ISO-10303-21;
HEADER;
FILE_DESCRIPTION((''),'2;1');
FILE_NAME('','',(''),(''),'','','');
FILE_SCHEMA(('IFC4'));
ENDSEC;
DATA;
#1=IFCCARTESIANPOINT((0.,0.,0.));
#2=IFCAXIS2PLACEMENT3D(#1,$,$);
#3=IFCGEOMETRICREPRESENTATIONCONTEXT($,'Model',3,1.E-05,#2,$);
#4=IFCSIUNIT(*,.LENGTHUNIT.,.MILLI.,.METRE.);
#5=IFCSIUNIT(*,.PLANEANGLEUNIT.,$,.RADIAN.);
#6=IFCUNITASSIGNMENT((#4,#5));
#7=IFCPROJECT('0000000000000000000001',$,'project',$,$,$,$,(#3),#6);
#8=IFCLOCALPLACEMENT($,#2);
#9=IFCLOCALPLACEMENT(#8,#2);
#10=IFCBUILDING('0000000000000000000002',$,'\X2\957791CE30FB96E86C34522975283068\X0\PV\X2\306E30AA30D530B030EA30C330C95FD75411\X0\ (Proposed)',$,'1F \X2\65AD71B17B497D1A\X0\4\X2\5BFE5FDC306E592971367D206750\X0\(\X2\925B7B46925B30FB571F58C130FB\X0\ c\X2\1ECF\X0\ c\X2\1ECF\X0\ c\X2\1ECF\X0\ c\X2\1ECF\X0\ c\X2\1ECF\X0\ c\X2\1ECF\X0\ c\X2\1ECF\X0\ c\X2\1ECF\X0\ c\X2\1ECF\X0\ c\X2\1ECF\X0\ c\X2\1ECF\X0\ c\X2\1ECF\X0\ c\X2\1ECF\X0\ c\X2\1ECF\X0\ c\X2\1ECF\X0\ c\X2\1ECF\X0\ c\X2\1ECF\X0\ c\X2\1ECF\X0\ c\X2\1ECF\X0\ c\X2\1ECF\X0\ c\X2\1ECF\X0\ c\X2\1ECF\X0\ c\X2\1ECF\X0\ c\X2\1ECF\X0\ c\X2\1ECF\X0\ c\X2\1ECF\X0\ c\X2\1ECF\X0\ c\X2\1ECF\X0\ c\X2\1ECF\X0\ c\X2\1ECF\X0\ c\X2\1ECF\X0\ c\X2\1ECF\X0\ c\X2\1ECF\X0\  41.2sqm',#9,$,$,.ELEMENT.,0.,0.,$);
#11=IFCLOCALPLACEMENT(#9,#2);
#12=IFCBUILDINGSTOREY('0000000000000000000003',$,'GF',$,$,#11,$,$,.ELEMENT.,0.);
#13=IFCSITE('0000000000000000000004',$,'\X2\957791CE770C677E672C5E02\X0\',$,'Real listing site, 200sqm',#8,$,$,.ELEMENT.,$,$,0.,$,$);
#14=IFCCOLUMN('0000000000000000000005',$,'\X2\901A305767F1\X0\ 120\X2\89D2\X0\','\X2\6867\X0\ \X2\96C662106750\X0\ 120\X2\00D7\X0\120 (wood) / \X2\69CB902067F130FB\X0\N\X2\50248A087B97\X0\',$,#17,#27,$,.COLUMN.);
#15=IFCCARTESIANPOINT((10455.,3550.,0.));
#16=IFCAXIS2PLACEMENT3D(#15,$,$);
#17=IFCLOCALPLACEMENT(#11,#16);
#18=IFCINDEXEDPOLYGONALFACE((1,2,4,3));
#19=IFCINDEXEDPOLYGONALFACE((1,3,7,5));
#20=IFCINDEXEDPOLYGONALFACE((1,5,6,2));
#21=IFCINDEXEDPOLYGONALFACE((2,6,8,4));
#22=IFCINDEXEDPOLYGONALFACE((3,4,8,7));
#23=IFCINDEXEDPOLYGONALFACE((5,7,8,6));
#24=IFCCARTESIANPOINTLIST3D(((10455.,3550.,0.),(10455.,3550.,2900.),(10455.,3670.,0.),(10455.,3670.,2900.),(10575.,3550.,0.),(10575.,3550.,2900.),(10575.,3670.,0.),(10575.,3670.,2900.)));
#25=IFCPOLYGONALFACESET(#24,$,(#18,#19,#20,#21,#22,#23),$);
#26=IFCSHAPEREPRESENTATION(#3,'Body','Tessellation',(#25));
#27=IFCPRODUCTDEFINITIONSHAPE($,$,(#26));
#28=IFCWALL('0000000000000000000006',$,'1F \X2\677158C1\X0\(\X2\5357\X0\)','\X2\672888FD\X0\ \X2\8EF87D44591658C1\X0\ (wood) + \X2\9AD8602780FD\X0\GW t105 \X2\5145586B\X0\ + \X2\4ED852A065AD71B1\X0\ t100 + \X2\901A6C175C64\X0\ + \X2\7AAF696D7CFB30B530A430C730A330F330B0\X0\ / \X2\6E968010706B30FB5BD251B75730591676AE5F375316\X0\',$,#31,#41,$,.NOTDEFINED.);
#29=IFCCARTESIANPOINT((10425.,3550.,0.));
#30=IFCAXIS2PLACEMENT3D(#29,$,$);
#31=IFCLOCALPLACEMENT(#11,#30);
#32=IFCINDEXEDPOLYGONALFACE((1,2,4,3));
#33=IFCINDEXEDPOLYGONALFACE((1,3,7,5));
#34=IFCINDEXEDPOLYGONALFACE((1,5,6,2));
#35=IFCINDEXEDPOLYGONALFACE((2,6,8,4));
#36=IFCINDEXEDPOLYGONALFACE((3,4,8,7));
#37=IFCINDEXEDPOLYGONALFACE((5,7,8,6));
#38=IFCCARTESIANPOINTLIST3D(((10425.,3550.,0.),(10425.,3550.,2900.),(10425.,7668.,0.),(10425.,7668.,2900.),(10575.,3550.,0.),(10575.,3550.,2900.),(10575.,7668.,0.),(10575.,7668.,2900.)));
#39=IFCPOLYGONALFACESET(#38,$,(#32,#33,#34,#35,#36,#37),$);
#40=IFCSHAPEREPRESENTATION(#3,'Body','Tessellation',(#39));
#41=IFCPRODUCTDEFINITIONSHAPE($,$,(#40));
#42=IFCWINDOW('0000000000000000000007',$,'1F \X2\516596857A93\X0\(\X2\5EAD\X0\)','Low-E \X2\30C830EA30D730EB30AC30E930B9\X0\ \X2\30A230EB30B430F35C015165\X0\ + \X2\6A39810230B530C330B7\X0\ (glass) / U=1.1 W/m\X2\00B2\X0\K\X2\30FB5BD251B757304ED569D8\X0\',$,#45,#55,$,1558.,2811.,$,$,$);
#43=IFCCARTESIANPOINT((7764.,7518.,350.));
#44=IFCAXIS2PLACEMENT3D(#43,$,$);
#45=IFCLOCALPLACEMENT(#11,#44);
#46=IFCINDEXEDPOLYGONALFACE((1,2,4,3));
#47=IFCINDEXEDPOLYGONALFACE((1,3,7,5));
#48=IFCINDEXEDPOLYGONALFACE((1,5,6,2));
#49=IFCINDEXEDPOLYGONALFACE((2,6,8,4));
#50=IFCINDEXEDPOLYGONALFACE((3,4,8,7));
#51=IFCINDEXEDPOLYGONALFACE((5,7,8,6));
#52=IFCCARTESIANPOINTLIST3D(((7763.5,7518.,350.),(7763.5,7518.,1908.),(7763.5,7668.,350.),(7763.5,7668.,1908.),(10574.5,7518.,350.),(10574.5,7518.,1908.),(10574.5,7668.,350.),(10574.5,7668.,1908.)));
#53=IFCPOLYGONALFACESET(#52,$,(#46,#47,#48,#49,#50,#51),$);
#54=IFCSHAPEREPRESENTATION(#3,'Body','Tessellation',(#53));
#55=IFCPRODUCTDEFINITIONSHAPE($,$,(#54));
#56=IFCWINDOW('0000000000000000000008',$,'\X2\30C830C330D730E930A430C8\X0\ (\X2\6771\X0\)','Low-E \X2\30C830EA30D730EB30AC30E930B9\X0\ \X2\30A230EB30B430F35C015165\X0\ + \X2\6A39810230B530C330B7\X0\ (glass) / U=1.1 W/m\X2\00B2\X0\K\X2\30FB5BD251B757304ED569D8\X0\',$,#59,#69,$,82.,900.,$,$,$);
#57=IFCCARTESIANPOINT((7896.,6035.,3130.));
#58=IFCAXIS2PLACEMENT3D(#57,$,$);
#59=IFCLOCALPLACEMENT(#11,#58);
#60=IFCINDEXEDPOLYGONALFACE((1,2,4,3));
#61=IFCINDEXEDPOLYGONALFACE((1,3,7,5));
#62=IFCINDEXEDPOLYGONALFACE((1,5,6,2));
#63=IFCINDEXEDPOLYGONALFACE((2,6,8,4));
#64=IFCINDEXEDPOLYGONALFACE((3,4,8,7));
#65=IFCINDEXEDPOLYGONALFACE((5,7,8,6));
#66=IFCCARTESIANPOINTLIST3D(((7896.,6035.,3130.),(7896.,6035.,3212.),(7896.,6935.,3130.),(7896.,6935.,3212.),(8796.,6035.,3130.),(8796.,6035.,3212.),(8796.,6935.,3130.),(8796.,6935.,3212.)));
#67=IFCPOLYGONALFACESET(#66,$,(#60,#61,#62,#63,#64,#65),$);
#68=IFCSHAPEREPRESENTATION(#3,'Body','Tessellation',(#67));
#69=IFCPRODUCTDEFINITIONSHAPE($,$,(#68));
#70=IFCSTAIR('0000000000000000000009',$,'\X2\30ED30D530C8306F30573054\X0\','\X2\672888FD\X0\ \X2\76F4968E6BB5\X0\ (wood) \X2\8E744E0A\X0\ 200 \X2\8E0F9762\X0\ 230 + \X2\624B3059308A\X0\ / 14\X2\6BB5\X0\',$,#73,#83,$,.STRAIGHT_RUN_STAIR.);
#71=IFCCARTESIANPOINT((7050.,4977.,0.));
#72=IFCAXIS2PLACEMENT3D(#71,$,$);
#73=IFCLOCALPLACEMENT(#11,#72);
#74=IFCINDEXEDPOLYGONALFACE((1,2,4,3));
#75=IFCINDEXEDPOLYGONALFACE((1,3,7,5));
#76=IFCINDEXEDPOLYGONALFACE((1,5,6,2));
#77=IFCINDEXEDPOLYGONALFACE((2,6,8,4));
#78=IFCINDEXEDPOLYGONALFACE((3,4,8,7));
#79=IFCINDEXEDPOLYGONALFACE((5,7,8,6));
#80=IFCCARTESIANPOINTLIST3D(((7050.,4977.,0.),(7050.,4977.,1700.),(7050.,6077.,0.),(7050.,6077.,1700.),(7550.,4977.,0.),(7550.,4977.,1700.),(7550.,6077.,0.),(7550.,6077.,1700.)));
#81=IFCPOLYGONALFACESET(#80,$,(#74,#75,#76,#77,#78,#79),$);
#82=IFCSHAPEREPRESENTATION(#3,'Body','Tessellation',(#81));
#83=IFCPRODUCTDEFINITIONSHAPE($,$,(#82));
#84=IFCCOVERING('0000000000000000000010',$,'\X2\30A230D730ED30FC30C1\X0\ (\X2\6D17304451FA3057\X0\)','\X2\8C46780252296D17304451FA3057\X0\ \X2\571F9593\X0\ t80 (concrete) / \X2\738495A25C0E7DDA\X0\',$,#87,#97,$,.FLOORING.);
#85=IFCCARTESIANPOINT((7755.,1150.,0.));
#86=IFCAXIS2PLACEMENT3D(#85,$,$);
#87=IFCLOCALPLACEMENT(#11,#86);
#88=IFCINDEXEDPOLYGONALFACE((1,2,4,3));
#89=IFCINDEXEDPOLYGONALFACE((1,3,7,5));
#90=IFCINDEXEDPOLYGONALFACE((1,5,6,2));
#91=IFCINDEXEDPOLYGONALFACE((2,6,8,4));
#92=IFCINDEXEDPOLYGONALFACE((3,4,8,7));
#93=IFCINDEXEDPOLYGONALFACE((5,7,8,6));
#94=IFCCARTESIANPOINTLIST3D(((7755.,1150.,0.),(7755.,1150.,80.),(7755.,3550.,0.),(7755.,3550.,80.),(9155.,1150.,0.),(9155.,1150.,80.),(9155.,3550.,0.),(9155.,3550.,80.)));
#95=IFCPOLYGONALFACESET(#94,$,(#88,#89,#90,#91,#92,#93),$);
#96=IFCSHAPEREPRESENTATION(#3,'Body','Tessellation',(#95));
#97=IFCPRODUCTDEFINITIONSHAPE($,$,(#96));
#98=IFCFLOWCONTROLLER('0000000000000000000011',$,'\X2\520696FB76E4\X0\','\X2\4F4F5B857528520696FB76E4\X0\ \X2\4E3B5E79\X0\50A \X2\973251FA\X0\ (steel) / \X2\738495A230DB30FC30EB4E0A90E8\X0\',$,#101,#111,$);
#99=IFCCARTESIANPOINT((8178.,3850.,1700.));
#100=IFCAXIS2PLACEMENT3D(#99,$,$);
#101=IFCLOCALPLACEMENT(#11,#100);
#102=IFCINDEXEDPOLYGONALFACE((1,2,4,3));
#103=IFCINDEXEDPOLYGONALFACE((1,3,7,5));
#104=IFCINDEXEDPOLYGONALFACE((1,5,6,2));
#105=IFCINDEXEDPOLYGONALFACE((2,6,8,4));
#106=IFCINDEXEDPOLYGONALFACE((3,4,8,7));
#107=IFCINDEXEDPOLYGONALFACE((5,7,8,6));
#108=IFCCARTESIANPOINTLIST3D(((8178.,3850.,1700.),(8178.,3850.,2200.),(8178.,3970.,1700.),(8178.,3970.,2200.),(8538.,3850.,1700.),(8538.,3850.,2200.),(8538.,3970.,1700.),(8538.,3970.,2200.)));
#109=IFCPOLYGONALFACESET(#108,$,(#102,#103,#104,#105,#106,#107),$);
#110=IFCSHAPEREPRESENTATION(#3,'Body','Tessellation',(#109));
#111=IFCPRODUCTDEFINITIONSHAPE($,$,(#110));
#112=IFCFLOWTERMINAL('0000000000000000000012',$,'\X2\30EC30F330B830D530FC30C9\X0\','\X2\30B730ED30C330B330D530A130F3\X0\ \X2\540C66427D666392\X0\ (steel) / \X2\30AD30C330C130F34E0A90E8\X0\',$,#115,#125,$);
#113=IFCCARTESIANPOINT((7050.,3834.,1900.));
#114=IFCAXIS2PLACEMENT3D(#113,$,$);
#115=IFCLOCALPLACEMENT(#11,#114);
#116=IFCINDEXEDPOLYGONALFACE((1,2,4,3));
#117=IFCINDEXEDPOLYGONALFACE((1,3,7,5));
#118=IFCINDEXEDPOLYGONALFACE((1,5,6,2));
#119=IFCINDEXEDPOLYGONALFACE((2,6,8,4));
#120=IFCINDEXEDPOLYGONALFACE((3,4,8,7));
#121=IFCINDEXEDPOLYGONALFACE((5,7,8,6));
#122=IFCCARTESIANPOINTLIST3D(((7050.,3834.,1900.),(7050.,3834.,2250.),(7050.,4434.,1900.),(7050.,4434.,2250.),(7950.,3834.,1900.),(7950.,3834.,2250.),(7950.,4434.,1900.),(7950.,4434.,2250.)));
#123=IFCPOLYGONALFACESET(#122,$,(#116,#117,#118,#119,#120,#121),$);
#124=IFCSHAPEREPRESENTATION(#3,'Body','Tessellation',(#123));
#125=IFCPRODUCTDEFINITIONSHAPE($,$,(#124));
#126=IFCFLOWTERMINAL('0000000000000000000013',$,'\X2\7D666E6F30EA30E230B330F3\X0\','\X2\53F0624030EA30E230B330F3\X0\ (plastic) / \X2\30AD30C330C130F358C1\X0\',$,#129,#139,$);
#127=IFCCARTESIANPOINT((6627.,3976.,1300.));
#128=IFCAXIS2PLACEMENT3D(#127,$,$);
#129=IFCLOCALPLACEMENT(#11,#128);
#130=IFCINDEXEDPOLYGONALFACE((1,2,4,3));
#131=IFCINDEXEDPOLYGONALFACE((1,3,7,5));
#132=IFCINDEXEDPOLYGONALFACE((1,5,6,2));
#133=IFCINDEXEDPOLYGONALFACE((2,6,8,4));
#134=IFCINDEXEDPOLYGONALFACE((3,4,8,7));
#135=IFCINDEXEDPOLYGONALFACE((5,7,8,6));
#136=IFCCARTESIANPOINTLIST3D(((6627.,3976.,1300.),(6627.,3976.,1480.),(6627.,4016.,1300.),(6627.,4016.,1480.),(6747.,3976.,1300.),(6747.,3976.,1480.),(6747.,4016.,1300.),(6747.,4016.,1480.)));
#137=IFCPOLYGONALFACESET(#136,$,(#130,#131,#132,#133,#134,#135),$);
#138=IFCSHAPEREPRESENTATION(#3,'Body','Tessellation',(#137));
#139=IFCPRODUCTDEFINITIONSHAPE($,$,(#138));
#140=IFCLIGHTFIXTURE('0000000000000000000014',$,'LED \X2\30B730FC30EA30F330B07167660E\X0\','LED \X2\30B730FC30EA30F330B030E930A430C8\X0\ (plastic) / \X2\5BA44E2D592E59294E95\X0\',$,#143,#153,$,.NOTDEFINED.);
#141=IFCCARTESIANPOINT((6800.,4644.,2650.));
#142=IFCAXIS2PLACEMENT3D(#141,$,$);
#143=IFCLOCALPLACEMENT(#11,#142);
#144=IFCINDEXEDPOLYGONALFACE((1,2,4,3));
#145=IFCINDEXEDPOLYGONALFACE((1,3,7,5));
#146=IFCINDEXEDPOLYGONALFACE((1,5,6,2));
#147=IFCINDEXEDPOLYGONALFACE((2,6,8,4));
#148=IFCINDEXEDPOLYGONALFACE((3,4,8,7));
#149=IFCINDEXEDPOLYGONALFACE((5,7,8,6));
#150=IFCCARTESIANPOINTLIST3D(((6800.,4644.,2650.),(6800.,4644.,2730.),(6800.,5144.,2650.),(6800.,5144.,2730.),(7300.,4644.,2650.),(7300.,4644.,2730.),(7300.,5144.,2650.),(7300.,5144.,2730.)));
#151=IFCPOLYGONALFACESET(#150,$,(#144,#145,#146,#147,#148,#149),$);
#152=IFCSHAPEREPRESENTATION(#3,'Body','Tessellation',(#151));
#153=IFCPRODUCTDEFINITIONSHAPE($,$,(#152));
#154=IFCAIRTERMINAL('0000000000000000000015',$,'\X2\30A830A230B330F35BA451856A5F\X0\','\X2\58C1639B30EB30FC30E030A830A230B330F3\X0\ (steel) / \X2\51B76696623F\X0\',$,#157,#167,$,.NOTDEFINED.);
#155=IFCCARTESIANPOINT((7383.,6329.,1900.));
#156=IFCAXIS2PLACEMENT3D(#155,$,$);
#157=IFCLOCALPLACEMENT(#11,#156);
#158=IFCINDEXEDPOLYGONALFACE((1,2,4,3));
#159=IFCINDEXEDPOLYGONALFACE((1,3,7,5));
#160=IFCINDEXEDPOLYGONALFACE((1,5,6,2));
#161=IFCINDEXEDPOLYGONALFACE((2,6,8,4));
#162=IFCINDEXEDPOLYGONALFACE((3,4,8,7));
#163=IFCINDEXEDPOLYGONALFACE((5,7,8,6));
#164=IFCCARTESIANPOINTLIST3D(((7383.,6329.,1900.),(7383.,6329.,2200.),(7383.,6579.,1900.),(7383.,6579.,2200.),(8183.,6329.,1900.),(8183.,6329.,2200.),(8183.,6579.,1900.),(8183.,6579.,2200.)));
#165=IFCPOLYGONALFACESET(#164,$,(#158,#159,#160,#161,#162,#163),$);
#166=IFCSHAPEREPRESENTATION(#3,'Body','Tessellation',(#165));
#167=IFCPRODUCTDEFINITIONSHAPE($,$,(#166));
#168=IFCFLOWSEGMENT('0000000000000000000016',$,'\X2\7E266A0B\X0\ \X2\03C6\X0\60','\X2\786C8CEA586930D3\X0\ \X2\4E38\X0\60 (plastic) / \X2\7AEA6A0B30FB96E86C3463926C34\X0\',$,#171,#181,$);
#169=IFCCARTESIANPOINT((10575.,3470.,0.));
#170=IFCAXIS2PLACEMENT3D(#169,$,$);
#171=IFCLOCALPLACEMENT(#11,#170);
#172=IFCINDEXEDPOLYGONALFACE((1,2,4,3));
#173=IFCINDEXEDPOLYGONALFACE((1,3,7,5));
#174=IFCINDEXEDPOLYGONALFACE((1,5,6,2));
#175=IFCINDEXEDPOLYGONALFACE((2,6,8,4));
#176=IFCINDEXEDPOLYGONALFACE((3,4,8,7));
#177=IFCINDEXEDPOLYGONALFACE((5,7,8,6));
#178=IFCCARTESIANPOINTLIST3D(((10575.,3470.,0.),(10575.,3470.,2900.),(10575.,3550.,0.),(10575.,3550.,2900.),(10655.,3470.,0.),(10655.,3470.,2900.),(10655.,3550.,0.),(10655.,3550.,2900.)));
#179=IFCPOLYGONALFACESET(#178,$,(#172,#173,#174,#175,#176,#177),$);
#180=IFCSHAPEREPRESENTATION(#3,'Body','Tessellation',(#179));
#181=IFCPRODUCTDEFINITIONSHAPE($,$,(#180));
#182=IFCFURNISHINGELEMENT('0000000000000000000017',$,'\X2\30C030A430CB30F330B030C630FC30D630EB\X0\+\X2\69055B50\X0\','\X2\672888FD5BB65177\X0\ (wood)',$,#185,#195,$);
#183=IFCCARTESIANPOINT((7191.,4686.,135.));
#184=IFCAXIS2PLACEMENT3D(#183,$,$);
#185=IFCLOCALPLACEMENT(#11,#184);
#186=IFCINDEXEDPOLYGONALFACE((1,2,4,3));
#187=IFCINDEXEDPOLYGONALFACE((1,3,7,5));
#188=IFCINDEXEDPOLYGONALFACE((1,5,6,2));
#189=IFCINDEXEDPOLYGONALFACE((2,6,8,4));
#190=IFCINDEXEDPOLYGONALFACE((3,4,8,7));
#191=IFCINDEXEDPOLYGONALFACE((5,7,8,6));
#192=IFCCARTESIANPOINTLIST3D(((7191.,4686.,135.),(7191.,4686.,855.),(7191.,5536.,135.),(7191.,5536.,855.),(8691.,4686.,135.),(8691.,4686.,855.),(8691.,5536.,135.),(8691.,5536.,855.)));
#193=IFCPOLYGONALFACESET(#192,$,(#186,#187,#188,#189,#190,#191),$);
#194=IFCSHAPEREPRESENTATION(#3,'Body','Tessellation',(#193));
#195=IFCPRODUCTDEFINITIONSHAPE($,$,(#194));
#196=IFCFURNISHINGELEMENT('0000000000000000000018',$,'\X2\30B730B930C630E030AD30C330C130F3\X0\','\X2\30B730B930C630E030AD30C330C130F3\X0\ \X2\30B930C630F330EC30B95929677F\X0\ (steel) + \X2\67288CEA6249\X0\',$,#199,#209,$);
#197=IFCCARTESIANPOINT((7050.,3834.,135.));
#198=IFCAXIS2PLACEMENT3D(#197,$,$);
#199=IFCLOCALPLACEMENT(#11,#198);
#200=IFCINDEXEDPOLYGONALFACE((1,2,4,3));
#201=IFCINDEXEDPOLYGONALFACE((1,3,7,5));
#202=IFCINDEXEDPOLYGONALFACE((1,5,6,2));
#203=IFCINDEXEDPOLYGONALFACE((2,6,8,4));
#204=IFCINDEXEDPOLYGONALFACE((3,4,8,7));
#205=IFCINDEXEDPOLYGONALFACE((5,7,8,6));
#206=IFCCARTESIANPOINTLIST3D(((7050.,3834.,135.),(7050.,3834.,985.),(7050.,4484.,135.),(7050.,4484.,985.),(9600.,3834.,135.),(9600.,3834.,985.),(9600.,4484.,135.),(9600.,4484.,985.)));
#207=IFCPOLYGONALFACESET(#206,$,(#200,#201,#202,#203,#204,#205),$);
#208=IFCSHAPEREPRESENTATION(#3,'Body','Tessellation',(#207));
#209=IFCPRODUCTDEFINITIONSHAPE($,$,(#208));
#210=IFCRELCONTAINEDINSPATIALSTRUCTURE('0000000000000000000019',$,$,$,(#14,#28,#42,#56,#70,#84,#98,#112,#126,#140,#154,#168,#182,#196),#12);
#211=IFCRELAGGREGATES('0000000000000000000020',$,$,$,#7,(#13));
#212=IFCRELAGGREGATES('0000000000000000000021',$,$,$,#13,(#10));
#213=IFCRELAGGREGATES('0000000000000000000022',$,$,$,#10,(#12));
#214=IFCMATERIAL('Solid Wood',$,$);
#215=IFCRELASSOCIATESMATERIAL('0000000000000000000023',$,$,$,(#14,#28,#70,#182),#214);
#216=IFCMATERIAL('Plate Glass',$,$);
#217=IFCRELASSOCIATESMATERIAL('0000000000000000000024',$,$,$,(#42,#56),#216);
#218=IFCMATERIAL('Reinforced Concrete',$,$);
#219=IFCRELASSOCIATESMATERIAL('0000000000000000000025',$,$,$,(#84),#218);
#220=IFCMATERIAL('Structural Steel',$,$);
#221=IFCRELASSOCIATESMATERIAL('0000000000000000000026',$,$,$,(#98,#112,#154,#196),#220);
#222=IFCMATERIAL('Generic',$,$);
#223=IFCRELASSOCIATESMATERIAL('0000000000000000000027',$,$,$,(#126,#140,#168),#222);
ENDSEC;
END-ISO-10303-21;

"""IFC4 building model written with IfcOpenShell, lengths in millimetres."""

from ifc_helpers import new_model, si_unit, frame, frame_2d, origin, place, context, project, spatial, rectangle, extrude, material, element, fill, save


model = new_model("IFC4")

# Units and contexts
model_context = context("Model", 3, precision=1e-05, world=origin())
ifc_project = project(units=[si_unit("LENGTHUNIT", "METRE", prefix="MILLI"), si_unit("PLANEANGLEUNIT", "RADIAN")], contexts=[model_context])

# Site, building, storey
site_placement = place(None, origin())
site = spatial("IfcSite", under=ifc_project, at=site_placement, Name="長野県松本市", ObjectType="Real listing site, 200sqm", CompositionType="ELEMENT", RefElevation=0.0)
building_placement = place(site_placement, origin())
building = spatial("IfcBuilding", under=site, at=building_placement, Name="長野・雨水利用とPVのオフグリッド志向 (Proposed)", ObjectType="1F 断熱等級4対応の天然素材(鉛筆鉛・土壁・ cỏ cỏ cỏ cỏ cỏ cỏ cỏ cỏ cỏ cỏ cỏ cỏ cỏ cỏ cỏ cỏ cỏ cỏ cỏ cỏ cỏ cỏ cỏ cỏ cỏ cỏ cỏ cỏ cỏ cỏ cỏ cỏ cỏ  41.2sqm", CompositionType="ELEMENT", ElevationOfRefHeight=0.0, ElevationOfTerrain=0.0)
storey_placement = place(building_placement, origin())
storey = spatial("IfcBuildingStorey", under=building, at=storey_placement, Name="GF", CompositionType="ELEMENT", Elevation=0.0)

# Column
ifc_material_1 = material(Name="Solid Wood")
column_1_placement = place(storey_placement, frame((10455.0, 3550.0, 0.0)))
element("IfcColumn", 1, at=column_1_placement, inside=storey, material=ifc_material_1, Name="通し柱 120角", Description="桧 集成材 120×120 (wood) / 構造柱・N値計算", PredefinedType="COLUMN", context=model_context, shape_type="SweptSolid", body=[
    extrude(rectangle(XDim=120.0, YDim=120.0, at=frame_2d((60.0, 60.0))), frame((10455.0, 3550.0, 0.0)), (0.0, 0.0, 1.0), 2900.0),
])

# Wall, opening, window
wall_1_placement = place(storey_placement, frame((10425.0, 3550.0, 0.0)))
wall_1 = element("IfcWall", 2, at=wall_1_placement, inside=storey, material=ifc_material_1, Name="1F 東壁(南)", Description="木製 軸組外壁 (wood) + 高性能GW t105 充填 + 付加断熱 t100 + 通気層 + 窯業系サイディング / 準耐火・寒冷地外皮強化", PredefinedType="NOTDEFINED", context=model_context, shape_type="SweptSolid", body=[
    extrude(rectangle(XDim=150.0, YDim=4118.0, at=frame_2d((75.0, 2059.0))), frame((10425.0, 3550.0, 0.0)), (0.0, 0.0, 1.0), 2900.0),
])
opening_1_placement = place(storey_placement, frame((7764.0, 7518.0, 350.0)))
opening_1 = element("IfcOpeningElement", 3, at=opening_1_placement, cuts=wall_1, PredefinedType="NOTDEFINED", context=model_context, shape_type="SweptSolid", body=[
    extrude(rectangle(XDim=2811.0, YDim=150.0, at=frame_2d((1405.0, 75.0))), frame((7764.0, 7518.0, 350.0)), (0.0, 0.0, 1.0), 1558.0),
])
ifc_material_2 = material(Name="Plate Glass")
window_1_placement = place(storey_placement, frame((7764.0, 7518.0, 350.0)))
window_1 = element("IfcWindow", 4, at=window_1_placement, inside=storey, material=ifc_material_2, Name="1F 入隅窓(庭)", Description="Low-E トリプルガラス アルゴン封入 + 樹脂サッシ (glass) / U=1.1 W/m²K・寒冷地仕様", OverallHeight=1558.0, OverallWidth=2811.0, context=model_context, shape_type="SweptSolid", body=[
    extrude(rectangle(XDim=2811.0, YDim=150.0, at=frame_2d((1405.0, 75.0))), frame((7764.0, 7518.0, 350.0)), (0.0, 0.0, 1.0), 1558.0),
])
fill(opening_1, window_1)

# Window
window_2_placement = place(storey_placement, frame((7896.0, 6035.0, 3130.0)))
element("IfcWindow", 5, at=window_2_placement, inside=storey, material=ifc_material_2, Name="トップライト (東)", Description="Low-E トリプルガラス アルゴン封入 + 樹脂サッシ (glass) / U=1.1 W/m²K・寒冷地仕様", OverallHeight=82.0, OverallWidth=900.0, context=model_context, shape_type="SweptSolid", body=[
    extrude(rectangle(XDim=900.0, YDim=900.0, at=frame_2d((450.0, 450.0))), frame((7896.0, 6035.0, 3130.0)), (0.0, 0.0, 1.0), 82.0),
])

# Stair
stair_placement = place(storey_placement, frame((7050.0, 4977.0, 0.0)))
element("IfcStair", 6, at=stair_placement, inside=storey, material=ifc_material_1, Name="ロフトはしご", Description="木製 直階段 (wood) 蹴上 200 踏面 230 + 手すり / 14段", PredefinedType="STRAIGHT_RUN_STAIR", context=model_context, shape_type="SweptSolid", body=[
    extrude(rectangle(XDim=500.0, YDim=1100.0, at=frame_2d((250.0, 550.0))), frame((7050.0, 4977.0, 0.0)), (0.0, 0.0, 1.0), 1700.0),
])

# Covering
ifc_material_3 = material(Name="Reinforced Concrete")
covering_placement = place(storey_placement, frame((7755.0, 1150.0, 0.0)))
element("IfcCovering", 7, at=covering_placement, inside=storey, material=ifc_material_3, Name="アプローチ (洗い出し)", Description="豆砂利洗い出し 土間 t80 (concrete) / 玄関導線", PredefinedType="FLOORING", context=model_context, shape_type="SweptSolid", body=[
    extrude(rectangle(XDim=1400.0, YDim=2400.0, at=frame_2d((700.0, 1200.0))), frame((7755.0, 1150.0, 0.0)), (0.0, 0.0, 1.0), 80.0),
])

# Flow controller
ifc_material_4 = material(Name="Structural Steel")
flow_controller_placement = place(storey_placement, frame((8178.0, 3850.0, 1700.0)))
element("IfcFlowController", 8, at=flow_controller_placement, inside=storey, material=ifc_material_4, Name="分電盤", Description="住宅用分電盤 主幹50A 露出 (steel) / 玄関ホール上部", context=model_context, shape_type="SweptSolid", body=[
    extrude(rectangle(XDim=360.0, YDim=120.0, at=frame_2d((180.0, 60.0))), frame((8178.0, 3850.0, 1700.0)), (0.0, 0.0, 1.0), 500.0),
])

# Flow terminals
flow_terminal_1_placement = place(storey_placement, frame((7050.0, 3834.0, 1900.0)))
element("IfcFlowTerminal", 9, at=flow_terminal_1_placement, inside=storey, material=ifc_material_4, Name="レンジフード", Description="シロッコファン 同時給排 (steel) / キッチン上部", context=model_context, shape_type="SweptSolid", body=[
    extrude(rectangle(XDim=900.0, YDim=600.0, at=frame_2d((450.0, 300.0))), frame((7050.0, 3834.0, 1900.0)), (0.0, 0.0, 1.0), 350.0),
])
ifc_material_5 = material(Name="Generic")
flow_terminal_2_placement = place(storey_placement, frame((6627.0, 3976.0, 1300.0)))
element("IfcFlowTerminal", 10, at=flow_terminal_2_placement, inside=storey, material=ifc_material_5, Name="給湯リモコン", Description="台所リモコン (plastic) / キッチン壁", context=model_context, shape_type="SweptSolid", body=[
    extrude(rectangle(XDim=120.0, YDim=40.0, at=frame_2d((60.0, 20.0))), frame((6627.0, 3976.0, 1300.0)), (0.0, 0.0, 1.0), 180.0),
])

# Light fixture
light_fixture_placement = place(storey_placement, frame((6800.0, 4644.0, 2650.0)))
element("IfcLightFixture", 11, at=light_fixture_placement, inside=storey, material=ifc_material_5, Name="LED シーリング照明", Description="LED シーリングライト (plastic) / 室中央天井", PredefinedType="NOTDEFINED", context=model_context, shape_type="SweptSolid", body=[
    extrude(rectangle(XDim=500.0, YDim=500.0, at=frame_2d((250.0, 250.0))), frame((6800.0, 4644.0, 2650.0)), (0.0, 0.0, 1.0), 80.0),
])

# Air terminal
air_terminal_placement = place(storey_placement, frame((7383.0, 6329.0, 1900.0)))
element("IfcAirTerminal", 12, at=air_terminal_placement, inside=storey, material=ifc_material_4, Name="エアコン室内機", Description="壁掛ルームエアコン (steel) / 冷暖房", PredefinedType="NOTDEFINED", context=model_context, shape_type="SweptSolid", body=[
    extrude(rectangle(XDim=800.0, YDim=250.0, at=frame_2d((400.0, 125.0))), frame((7383.0, 6329.0, 1900.0)), (0.0, 0.0, 1.0), 300.0),
])

# Flow segment
flow_segment_placement = place(storey_placement, frame((10575.0, 3470.0, 0.0)))
element("IfcFlowSegment", 13, at=flow_segment_placement, inside=storey, material=ifc_material_5, Name="縦樋 φ60", Description="硬質塩ビ 丸60 (plastic) / 竪樋・雨水排水", context=model_context, shape_type="SweptSolid", body=[
    extrude(rectangle(XDim=80.0, YDim=80.0, at=frame_2d((40.0, 40.0))), frame((10575.0, 3470.0, 0.0)), (0.0, 0.0, 1.0), 2900.0),
])

# Furnishing elements
furnishing_1_placement = place(storey_placement, frame((7191.0, 4686.0, 135.0)))
element("IfcFurnishingElement", 14, at=furnishing_1_placement, inside=storey, material=ifc_material_1, Name="ダイニングテーブル+椅子", Description="木製家具 (wood)", context=model_context, shape_type="SweptSolid", body=[
    extrude(rectangle(XDim=1500.0, YDim=850.0, at=frame_2d((750.0, 425.0))), frame((7191.0, 4686.0, 135.0)), (0.0, 0.0, 1.0), 720.0),
])
furnishing_2_placement = place(storey_placement, frame((7050.0, 3834.0, 135.0)))
element("IfcFurnishingElement", 15, at=furnishing_2_placement, inside=storey, material=ifc_material_4, Name="システムキッチン", Description="システムキッチン ステンレス天板 (steel) + 木質扉", context=model_context, shape_type="SweptSolid", body=[
    extrude(rectangle(XDim=2550.0, YDim=650.0, at=frame_2d((1275.0, 325.0))), frame((7050.0, 3834.0, 135.0)), (0.0, 0.0, 1.0), 850.0),
])

save(model, "model.ifc")
